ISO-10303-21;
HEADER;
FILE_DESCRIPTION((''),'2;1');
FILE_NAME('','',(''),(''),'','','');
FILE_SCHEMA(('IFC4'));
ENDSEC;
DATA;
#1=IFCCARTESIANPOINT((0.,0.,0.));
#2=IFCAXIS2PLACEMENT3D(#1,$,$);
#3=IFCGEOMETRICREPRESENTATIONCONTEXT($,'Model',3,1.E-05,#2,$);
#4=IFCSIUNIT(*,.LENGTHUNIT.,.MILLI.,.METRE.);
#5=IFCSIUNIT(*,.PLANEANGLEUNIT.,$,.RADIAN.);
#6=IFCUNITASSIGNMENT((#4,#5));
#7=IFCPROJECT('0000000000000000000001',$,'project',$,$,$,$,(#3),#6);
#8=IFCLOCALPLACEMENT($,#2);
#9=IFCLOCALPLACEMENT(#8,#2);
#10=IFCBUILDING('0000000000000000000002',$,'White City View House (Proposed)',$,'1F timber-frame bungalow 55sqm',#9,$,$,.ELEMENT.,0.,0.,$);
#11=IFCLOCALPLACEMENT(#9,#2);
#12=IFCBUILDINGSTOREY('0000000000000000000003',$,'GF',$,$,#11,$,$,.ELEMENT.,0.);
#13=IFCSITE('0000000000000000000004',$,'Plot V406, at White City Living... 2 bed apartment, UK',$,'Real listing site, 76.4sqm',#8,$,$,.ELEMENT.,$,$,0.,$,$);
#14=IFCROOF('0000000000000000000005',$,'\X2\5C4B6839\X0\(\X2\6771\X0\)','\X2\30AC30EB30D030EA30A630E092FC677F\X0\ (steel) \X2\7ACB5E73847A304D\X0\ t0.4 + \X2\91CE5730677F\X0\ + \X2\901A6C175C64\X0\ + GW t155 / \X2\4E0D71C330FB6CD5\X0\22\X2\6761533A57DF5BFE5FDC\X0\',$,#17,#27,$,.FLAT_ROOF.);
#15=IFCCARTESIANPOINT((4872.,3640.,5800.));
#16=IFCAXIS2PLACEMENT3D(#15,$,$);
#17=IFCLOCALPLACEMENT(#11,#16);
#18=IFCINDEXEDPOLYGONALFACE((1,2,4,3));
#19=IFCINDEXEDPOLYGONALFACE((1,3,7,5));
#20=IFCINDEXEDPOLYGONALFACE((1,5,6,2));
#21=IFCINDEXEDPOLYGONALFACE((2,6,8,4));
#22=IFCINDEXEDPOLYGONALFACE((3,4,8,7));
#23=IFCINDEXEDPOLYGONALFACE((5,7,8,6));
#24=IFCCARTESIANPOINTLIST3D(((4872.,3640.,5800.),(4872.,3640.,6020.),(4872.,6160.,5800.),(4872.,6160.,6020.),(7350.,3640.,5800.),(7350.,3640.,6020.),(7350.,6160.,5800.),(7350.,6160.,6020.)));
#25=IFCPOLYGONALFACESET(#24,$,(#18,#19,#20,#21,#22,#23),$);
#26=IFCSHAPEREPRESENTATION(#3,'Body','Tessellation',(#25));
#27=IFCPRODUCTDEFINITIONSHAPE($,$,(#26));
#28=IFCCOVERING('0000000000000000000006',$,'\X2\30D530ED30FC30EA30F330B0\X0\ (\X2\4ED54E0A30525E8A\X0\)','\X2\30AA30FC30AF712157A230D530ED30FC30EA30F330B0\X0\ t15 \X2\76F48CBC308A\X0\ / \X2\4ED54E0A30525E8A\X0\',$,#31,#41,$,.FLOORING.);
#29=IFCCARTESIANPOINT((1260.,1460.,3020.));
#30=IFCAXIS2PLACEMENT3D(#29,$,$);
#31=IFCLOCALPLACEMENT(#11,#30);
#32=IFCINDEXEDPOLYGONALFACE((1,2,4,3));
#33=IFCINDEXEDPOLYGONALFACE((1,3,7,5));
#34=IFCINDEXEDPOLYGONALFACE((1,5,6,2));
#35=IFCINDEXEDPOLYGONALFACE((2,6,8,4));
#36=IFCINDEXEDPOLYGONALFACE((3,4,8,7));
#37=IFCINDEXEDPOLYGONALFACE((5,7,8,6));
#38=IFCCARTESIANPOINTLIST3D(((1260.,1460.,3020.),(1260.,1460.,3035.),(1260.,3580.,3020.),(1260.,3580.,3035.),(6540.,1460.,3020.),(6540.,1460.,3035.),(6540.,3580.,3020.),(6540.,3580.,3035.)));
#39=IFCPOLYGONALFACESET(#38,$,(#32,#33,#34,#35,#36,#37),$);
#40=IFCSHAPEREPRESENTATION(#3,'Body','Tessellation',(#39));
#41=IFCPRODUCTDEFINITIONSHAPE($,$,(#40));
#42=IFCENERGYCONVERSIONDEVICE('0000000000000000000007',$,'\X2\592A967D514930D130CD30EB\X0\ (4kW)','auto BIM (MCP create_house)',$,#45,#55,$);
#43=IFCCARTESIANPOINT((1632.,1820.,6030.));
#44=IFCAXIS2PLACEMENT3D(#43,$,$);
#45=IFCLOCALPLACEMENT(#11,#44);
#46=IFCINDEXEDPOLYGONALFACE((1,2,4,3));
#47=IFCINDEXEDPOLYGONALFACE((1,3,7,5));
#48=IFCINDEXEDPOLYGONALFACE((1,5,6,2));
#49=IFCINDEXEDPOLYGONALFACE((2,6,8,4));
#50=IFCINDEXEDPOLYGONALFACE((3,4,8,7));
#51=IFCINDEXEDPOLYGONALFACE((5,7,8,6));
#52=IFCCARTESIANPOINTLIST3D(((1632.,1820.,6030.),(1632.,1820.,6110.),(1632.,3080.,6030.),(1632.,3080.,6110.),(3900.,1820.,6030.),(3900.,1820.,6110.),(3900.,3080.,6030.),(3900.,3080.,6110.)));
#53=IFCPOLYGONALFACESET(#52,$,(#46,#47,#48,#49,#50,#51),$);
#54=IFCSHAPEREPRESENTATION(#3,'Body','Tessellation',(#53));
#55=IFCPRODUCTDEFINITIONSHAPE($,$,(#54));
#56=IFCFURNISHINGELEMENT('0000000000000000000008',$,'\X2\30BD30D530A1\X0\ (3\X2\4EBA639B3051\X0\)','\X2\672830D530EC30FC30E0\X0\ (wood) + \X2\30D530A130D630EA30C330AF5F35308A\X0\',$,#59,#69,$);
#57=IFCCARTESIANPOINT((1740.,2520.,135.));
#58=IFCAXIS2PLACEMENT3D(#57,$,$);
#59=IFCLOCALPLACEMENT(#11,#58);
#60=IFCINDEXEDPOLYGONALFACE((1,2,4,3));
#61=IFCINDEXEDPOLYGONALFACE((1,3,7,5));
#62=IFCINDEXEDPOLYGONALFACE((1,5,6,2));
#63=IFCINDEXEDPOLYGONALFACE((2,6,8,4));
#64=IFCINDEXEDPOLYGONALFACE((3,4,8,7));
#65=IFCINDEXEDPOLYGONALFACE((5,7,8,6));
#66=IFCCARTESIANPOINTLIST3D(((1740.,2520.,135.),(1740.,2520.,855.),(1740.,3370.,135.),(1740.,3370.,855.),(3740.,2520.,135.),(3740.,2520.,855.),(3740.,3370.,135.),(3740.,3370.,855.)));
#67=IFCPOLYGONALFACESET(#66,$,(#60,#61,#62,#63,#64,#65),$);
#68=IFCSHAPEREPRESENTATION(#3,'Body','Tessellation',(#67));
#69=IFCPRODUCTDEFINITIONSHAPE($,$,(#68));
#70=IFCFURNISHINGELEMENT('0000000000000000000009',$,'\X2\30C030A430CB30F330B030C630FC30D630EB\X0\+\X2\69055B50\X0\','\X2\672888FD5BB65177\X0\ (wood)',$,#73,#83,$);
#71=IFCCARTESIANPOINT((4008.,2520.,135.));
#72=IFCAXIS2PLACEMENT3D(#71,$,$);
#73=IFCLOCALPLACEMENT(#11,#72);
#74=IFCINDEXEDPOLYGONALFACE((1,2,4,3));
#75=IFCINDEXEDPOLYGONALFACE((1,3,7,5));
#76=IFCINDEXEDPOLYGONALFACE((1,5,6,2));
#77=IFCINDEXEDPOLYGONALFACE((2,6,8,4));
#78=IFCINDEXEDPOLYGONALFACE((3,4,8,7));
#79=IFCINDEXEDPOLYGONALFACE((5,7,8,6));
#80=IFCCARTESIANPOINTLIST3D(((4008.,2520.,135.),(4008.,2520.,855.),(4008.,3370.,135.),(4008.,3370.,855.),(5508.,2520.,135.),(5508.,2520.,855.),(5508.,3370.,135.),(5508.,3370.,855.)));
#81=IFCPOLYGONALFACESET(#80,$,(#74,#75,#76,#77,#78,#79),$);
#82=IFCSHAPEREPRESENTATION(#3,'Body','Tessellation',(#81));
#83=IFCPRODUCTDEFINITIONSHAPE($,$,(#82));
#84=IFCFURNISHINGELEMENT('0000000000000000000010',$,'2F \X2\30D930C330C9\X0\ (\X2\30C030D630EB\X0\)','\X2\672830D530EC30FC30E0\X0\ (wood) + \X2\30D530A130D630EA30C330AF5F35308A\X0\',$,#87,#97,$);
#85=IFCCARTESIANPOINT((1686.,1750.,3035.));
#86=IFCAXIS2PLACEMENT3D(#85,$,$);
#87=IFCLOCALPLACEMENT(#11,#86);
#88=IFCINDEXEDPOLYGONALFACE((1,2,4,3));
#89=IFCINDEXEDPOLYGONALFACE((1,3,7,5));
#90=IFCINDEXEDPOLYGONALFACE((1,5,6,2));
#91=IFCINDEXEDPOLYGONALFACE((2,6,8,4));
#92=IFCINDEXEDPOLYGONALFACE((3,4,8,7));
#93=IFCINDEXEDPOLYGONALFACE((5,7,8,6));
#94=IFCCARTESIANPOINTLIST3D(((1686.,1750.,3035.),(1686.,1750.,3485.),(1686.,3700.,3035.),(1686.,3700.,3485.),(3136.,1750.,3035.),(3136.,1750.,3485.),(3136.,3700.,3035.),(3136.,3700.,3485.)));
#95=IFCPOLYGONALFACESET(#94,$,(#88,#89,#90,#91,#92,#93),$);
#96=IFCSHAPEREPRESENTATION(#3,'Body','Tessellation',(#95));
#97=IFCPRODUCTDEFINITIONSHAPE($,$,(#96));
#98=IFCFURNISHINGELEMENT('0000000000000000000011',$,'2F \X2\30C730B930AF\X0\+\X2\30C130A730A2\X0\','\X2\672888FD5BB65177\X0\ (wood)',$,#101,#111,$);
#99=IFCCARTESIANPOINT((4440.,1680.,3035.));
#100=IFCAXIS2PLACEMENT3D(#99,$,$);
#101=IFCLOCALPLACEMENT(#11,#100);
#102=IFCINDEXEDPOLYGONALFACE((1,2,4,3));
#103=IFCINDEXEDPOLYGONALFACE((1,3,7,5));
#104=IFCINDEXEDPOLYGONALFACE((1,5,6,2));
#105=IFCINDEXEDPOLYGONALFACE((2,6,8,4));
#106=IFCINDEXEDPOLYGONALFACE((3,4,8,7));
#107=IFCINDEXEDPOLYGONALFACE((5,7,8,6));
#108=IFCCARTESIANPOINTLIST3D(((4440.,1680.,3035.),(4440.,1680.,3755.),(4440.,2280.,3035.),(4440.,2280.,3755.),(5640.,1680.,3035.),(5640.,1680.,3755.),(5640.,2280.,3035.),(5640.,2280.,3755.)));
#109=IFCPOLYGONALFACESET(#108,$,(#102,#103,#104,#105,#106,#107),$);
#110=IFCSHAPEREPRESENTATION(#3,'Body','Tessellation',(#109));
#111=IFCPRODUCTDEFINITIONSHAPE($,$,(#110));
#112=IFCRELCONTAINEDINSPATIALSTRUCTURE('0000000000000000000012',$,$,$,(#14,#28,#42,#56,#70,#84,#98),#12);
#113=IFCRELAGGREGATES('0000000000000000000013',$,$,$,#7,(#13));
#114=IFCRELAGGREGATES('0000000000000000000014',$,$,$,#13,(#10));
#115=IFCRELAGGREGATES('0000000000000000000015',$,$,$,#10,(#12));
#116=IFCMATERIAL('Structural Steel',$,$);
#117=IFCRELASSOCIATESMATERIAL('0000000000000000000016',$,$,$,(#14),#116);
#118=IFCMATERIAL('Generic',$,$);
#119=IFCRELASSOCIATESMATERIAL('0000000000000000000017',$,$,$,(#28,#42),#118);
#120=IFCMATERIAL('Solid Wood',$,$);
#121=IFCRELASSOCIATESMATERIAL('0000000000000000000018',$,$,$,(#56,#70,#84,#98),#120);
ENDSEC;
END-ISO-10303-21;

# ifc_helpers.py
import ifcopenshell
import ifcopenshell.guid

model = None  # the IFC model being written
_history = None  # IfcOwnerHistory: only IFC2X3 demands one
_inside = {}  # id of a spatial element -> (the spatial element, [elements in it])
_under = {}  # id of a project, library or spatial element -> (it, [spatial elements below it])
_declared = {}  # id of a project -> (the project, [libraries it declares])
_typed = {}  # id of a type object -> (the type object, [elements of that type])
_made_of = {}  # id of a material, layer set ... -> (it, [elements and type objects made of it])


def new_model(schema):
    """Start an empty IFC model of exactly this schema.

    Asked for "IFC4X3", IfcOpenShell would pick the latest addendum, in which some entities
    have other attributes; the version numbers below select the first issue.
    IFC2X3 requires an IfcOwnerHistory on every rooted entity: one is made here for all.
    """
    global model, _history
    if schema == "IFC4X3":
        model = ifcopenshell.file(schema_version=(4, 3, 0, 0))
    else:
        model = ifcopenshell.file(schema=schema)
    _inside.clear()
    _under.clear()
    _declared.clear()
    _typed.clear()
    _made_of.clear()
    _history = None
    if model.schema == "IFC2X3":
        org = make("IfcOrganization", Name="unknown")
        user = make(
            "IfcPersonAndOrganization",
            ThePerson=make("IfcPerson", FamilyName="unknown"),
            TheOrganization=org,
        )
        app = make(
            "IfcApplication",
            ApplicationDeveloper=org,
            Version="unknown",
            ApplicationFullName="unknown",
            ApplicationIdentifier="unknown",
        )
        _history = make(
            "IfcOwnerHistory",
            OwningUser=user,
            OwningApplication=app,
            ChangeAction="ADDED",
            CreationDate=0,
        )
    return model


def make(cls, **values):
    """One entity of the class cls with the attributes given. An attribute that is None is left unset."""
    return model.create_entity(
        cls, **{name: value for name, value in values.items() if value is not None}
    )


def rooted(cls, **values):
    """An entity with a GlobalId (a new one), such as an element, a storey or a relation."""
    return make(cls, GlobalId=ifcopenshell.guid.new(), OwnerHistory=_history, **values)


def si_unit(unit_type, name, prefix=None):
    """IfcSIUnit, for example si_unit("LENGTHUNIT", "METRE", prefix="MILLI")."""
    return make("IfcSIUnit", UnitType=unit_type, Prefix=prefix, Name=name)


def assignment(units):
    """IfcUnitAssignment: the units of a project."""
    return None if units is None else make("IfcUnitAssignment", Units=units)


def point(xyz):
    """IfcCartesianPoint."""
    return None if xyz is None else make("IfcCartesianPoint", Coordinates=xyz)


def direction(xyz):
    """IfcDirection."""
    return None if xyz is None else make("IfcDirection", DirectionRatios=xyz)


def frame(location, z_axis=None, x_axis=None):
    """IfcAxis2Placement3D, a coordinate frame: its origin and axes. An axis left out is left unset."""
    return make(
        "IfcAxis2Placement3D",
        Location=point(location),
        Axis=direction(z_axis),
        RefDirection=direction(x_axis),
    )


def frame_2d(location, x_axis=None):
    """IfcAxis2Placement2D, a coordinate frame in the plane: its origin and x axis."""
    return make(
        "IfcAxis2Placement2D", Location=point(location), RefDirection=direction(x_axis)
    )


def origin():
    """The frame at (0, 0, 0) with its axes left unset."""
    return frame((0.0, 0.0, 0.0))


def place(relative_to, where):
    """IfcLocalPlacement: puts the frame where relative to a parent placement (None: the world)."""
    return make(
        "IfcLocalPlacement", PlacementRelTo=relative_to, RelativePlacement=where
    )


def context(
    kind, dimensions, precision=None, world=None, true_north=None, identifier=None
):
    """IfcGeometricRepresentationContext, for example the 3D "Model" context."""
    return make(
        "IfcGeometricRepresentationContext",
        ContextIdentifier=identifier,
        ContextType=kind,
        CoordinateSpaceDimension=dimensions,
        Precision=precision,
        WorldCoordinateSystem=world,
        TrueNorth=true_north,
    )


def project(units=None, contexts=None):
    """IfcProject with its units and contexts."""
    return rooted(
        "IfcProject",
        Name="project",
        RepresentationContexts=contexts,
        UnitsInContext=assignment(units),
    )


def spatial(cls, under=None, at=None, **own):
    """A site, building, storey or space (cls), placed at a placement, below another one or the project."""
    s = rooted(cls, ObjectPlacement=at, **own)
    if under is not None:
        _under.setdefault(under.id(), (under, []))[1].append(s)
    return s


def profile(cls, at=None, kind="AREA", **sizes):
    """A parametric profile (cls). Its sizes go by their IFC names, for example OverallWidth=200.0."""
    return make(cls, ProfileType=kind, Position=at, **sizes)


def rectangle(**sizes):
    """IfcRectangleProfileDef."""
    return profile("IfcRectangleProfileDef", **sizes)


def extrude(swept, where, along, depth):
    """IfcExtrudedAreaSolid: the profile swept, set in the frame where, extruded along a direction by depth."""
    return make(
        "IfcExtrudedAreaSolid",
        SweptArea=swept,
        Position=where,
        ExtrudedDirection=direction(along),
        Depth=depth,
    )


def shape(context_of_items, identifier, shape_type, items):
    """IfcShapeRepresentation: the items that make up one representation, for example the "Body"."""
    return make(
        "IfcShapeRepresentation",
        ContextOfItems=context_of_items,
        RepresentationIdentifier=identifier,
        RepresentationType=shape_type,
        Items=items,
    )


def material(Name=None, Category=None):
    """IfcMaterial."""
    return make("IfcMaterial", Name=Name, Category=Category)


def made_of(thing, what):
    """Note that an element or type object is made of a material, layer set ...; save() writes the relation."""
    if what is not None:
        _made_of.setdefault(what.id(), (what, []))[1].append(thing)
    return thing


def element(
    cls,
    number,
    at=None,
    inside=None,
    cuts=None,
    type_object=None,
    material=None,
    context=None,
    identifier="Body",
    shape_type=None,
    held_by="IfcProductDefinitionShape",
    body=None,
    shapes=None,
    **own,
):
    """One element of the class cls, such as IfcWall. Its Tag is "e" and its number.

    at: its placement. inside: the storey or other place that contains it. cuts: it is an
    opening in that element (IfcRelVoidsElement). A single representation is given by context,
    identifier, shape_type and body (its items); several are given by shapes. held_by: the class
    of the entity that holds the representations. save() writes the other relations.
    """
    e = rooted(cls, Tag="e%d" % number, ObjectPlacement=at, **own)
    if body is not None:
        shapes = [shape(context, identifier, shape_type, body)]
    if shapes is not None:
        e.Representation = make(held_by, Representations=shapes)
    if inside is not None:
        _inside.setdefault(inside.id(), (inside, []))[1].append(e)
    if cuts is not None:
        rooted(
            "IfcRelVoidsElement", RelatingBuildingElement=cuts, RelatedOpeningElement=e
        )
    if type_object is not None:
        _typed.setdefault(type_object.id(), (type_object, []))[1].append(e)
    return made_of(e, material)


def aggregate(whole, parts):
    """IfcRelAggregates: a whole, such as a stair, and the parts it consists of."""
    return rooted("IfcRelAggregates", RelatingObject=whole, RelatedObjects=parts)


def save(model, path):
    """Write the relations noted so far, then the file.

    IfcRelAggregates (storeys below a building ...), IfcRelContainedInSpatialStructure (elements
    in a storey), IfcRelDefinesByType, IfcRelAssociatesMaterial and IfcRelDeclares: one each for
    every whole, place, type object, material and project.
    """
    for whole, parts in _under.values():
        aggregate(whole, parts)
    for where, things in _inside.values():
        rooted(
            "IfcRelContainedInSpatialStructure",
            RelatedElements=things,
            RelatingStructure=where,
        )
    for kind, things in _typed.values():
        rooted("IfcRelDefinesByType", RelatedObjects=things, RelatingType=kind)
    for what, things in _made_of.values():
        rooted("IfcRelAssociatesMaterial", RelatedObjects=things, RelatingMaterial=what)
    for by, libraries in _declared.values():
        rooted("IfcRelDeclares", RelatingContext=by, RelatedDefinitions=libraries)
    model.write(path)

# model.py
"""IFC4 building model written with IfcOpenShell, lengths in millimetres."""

from ifc_helpers import new_model, si_unit, frame, frame_2d, origin, place, context, project, spatial, rectangle, extrude, material, element, save


model = new_model("IFC4")

# Units and contexts
model_context = context("Model", 3, precision=1e-05, world=origin())
ifc_project = project(units=[si_unit("LENGTHUNIT", "METRE", prefix="MILLI"), si_unit("PLANEANGLEUNIT", "RADIAN")], contexts=[model_context])

# Site, building, storey
site_placement = place(None, origin())
site = spatial("IfcSite", under=ifc_project, at=site_placement, Name="Plot V406, at White City Living... 2 bed apartment, UK", ObjectType="Real listing site, 76.4sqm", CompositionType="ELEMENT", RefElevation=0.0)
building_placement = place(site_placement, origin())
building = spatial("IfcBuilding", under=site, at=building_placement, Name="White City View House (Proposed)", ObjectType="1F timber-frame bungalow 55sqm", CompositionType="ELEMENT", ElevationOfRefHeight=0.0, ElevationOfTerrain=0.0)
storey_placement = place(building_placement, origin())
storey = spatial("IfcBuildingStorey", under=building, at=storey_placement, Name="GF", CompositionType="ELEMENT", Elevation=0.0)

# Shared definitions
ifc_material_1 = material(Name="Solid Wood")

# Roof
ifc_material_2 = material(Name="Structural Steel")
roof_1_placement = place(storey_placement, frame((4872.0, 3640.0, 5800.0)))
element("IfcRoof", 1, at=roof_1_placement, inside=storey, material=ifc_material_2, Name="屋根(東)", Description="ガルバリウム鋼板 (steel) 立平葺き t0.4 + 野地板 + 通気層 + GW t155 / 不燃・法22条区域対応", PredefinedType="FLAT_ROOF", context=model_context, shape_type="SweptSolid", body=[
    extrude(rectangle(XDim=2478.0, YDim=2520.0, at=frame_2d((1239.0, 1260.0))), frame((4872.0, 3640.0, 5800.0)), (0.0, 0.0, 1.0), 220.0),
])

# Covering
ifc_material_3 = material(Name="Generic")
covering_placement = place(storey_placement, frame((1260.0, 1460.0, 3020.0)))
element("IfcCovering", 2, at=covering_placement, inside=storey, material=ifc_material_3, Name="フローリング (仕上げ床)", Description="オーク無垢フローリング t15 直貼り / 仕上げ床", PredefinedType="FLOORING", context=model_context, shape_type="SweptSolid", body=[
    extrude(rectangle(XDim=5280.0, YDim=2120.0, at=frame_2d((2640.0, 1060.0))), frame((1260.0, 1460.0, 3020.0)), (0.0, 0.0, 1.0), 15.0),
])

# Energy conversion device
energy_conversion_device_placement = place(storey_placement, frame((1632.0, 1820.0, 6030.0)))
element("IfcEnergyConversionDevice", 3, at=energy_conversion_device_placement, inside=storey, material=ifc_material_3, Name="太陽光パネル (4kW)", Description="auto BIM (MCP create_house)", context=model_context, shape_type="SweptSolid", body=[
    extrude(rectangle(XDim=2268.0, YDim=1260.0, at=frame_2d((1134.0, 630.0))), frame((1632.0, 1820.0, 6030.0)), (0.0, 0.0, 1.0), 80.0),
])

# Furnishing elements
furnishing_1_placement = place(storey_placement, frame((1740.0, 2520.0, 135.0)))
element("IfcFurnishingElement", 4, at=furnishing_1_placement, inside=storey, material=ifc_material_1, Name="ソファ (3人掛け)", Description="木フレーム (wood) + ファブリック張り", context=model_context, shape_type="SweptSolid", body=[
    extrude(rectangle(XDim=2000.0, YDim=850.0, at=frame_2d((1000.0, 425.0))), frame((1740.0, 2520.0, 135.0)), (0.0, 0.0, 1.0), 720.0),
])
furnishing_2_placement = place(storey_placement, frame((4008.0, 2520.0, 135.0)))
element("IfcFurnishingElement", 5, at=furnishing_2_placement, inside=storey, material=ifc_material_1, Name="ダイニングテーブル+椅子", Description="木製家具 (wood)", context=model_context, shape_type="SweptSolid", body=[
    extrude(rectangle(XDim=1500.0, YDim=850.0, at=frame_2d((750.0, 425.0))), frame((4008.0, 2520.0, 135.0)), (0.0, 0.0, 1.0), 720.0),
])
furnishing_3_placement = place(storey_placement, frame((1686.0, 1750.0, 3035.0)))
element("IfcFurnishingElement", 6, at=furnishing_3_placement, inside=storey, material=ifc_material_1, Name="2F ベッド (ダブル)", Description="木フレーム (wood) + ファブリック張り", context=model_context, shape_type="SweptSolid", body=[
    extrude(rectangle(XDim=1450.0, YDim=1950.0, at=frame_2d((725.0, 975.0))), frame((1686.0, 1750.0, 3035.0)), (0.0, 0.0, 1.0), 450.0),
])
furnishing_4_placement = place(storey_placement, frame((4440.0, 1680.0, 3035.0)))
element("IfcFurnishingElement", 7, at=furnishing_4_placement, inside=storey, material=ifc_material_1, Name="2F デスク+チェア", Description="木製家具 (wood)", context=model_context, shape_type="SweptSolid", body=[
    extrude(rectangle(XDim=1200.0, YDim=600.0, at=frame_2d((600.0, 300.0))), frame((4440.0, 1680.0, 3035.0)), (0.0, 0.0, 1.0), 720.0),
])

save(model, "model.ifc")
